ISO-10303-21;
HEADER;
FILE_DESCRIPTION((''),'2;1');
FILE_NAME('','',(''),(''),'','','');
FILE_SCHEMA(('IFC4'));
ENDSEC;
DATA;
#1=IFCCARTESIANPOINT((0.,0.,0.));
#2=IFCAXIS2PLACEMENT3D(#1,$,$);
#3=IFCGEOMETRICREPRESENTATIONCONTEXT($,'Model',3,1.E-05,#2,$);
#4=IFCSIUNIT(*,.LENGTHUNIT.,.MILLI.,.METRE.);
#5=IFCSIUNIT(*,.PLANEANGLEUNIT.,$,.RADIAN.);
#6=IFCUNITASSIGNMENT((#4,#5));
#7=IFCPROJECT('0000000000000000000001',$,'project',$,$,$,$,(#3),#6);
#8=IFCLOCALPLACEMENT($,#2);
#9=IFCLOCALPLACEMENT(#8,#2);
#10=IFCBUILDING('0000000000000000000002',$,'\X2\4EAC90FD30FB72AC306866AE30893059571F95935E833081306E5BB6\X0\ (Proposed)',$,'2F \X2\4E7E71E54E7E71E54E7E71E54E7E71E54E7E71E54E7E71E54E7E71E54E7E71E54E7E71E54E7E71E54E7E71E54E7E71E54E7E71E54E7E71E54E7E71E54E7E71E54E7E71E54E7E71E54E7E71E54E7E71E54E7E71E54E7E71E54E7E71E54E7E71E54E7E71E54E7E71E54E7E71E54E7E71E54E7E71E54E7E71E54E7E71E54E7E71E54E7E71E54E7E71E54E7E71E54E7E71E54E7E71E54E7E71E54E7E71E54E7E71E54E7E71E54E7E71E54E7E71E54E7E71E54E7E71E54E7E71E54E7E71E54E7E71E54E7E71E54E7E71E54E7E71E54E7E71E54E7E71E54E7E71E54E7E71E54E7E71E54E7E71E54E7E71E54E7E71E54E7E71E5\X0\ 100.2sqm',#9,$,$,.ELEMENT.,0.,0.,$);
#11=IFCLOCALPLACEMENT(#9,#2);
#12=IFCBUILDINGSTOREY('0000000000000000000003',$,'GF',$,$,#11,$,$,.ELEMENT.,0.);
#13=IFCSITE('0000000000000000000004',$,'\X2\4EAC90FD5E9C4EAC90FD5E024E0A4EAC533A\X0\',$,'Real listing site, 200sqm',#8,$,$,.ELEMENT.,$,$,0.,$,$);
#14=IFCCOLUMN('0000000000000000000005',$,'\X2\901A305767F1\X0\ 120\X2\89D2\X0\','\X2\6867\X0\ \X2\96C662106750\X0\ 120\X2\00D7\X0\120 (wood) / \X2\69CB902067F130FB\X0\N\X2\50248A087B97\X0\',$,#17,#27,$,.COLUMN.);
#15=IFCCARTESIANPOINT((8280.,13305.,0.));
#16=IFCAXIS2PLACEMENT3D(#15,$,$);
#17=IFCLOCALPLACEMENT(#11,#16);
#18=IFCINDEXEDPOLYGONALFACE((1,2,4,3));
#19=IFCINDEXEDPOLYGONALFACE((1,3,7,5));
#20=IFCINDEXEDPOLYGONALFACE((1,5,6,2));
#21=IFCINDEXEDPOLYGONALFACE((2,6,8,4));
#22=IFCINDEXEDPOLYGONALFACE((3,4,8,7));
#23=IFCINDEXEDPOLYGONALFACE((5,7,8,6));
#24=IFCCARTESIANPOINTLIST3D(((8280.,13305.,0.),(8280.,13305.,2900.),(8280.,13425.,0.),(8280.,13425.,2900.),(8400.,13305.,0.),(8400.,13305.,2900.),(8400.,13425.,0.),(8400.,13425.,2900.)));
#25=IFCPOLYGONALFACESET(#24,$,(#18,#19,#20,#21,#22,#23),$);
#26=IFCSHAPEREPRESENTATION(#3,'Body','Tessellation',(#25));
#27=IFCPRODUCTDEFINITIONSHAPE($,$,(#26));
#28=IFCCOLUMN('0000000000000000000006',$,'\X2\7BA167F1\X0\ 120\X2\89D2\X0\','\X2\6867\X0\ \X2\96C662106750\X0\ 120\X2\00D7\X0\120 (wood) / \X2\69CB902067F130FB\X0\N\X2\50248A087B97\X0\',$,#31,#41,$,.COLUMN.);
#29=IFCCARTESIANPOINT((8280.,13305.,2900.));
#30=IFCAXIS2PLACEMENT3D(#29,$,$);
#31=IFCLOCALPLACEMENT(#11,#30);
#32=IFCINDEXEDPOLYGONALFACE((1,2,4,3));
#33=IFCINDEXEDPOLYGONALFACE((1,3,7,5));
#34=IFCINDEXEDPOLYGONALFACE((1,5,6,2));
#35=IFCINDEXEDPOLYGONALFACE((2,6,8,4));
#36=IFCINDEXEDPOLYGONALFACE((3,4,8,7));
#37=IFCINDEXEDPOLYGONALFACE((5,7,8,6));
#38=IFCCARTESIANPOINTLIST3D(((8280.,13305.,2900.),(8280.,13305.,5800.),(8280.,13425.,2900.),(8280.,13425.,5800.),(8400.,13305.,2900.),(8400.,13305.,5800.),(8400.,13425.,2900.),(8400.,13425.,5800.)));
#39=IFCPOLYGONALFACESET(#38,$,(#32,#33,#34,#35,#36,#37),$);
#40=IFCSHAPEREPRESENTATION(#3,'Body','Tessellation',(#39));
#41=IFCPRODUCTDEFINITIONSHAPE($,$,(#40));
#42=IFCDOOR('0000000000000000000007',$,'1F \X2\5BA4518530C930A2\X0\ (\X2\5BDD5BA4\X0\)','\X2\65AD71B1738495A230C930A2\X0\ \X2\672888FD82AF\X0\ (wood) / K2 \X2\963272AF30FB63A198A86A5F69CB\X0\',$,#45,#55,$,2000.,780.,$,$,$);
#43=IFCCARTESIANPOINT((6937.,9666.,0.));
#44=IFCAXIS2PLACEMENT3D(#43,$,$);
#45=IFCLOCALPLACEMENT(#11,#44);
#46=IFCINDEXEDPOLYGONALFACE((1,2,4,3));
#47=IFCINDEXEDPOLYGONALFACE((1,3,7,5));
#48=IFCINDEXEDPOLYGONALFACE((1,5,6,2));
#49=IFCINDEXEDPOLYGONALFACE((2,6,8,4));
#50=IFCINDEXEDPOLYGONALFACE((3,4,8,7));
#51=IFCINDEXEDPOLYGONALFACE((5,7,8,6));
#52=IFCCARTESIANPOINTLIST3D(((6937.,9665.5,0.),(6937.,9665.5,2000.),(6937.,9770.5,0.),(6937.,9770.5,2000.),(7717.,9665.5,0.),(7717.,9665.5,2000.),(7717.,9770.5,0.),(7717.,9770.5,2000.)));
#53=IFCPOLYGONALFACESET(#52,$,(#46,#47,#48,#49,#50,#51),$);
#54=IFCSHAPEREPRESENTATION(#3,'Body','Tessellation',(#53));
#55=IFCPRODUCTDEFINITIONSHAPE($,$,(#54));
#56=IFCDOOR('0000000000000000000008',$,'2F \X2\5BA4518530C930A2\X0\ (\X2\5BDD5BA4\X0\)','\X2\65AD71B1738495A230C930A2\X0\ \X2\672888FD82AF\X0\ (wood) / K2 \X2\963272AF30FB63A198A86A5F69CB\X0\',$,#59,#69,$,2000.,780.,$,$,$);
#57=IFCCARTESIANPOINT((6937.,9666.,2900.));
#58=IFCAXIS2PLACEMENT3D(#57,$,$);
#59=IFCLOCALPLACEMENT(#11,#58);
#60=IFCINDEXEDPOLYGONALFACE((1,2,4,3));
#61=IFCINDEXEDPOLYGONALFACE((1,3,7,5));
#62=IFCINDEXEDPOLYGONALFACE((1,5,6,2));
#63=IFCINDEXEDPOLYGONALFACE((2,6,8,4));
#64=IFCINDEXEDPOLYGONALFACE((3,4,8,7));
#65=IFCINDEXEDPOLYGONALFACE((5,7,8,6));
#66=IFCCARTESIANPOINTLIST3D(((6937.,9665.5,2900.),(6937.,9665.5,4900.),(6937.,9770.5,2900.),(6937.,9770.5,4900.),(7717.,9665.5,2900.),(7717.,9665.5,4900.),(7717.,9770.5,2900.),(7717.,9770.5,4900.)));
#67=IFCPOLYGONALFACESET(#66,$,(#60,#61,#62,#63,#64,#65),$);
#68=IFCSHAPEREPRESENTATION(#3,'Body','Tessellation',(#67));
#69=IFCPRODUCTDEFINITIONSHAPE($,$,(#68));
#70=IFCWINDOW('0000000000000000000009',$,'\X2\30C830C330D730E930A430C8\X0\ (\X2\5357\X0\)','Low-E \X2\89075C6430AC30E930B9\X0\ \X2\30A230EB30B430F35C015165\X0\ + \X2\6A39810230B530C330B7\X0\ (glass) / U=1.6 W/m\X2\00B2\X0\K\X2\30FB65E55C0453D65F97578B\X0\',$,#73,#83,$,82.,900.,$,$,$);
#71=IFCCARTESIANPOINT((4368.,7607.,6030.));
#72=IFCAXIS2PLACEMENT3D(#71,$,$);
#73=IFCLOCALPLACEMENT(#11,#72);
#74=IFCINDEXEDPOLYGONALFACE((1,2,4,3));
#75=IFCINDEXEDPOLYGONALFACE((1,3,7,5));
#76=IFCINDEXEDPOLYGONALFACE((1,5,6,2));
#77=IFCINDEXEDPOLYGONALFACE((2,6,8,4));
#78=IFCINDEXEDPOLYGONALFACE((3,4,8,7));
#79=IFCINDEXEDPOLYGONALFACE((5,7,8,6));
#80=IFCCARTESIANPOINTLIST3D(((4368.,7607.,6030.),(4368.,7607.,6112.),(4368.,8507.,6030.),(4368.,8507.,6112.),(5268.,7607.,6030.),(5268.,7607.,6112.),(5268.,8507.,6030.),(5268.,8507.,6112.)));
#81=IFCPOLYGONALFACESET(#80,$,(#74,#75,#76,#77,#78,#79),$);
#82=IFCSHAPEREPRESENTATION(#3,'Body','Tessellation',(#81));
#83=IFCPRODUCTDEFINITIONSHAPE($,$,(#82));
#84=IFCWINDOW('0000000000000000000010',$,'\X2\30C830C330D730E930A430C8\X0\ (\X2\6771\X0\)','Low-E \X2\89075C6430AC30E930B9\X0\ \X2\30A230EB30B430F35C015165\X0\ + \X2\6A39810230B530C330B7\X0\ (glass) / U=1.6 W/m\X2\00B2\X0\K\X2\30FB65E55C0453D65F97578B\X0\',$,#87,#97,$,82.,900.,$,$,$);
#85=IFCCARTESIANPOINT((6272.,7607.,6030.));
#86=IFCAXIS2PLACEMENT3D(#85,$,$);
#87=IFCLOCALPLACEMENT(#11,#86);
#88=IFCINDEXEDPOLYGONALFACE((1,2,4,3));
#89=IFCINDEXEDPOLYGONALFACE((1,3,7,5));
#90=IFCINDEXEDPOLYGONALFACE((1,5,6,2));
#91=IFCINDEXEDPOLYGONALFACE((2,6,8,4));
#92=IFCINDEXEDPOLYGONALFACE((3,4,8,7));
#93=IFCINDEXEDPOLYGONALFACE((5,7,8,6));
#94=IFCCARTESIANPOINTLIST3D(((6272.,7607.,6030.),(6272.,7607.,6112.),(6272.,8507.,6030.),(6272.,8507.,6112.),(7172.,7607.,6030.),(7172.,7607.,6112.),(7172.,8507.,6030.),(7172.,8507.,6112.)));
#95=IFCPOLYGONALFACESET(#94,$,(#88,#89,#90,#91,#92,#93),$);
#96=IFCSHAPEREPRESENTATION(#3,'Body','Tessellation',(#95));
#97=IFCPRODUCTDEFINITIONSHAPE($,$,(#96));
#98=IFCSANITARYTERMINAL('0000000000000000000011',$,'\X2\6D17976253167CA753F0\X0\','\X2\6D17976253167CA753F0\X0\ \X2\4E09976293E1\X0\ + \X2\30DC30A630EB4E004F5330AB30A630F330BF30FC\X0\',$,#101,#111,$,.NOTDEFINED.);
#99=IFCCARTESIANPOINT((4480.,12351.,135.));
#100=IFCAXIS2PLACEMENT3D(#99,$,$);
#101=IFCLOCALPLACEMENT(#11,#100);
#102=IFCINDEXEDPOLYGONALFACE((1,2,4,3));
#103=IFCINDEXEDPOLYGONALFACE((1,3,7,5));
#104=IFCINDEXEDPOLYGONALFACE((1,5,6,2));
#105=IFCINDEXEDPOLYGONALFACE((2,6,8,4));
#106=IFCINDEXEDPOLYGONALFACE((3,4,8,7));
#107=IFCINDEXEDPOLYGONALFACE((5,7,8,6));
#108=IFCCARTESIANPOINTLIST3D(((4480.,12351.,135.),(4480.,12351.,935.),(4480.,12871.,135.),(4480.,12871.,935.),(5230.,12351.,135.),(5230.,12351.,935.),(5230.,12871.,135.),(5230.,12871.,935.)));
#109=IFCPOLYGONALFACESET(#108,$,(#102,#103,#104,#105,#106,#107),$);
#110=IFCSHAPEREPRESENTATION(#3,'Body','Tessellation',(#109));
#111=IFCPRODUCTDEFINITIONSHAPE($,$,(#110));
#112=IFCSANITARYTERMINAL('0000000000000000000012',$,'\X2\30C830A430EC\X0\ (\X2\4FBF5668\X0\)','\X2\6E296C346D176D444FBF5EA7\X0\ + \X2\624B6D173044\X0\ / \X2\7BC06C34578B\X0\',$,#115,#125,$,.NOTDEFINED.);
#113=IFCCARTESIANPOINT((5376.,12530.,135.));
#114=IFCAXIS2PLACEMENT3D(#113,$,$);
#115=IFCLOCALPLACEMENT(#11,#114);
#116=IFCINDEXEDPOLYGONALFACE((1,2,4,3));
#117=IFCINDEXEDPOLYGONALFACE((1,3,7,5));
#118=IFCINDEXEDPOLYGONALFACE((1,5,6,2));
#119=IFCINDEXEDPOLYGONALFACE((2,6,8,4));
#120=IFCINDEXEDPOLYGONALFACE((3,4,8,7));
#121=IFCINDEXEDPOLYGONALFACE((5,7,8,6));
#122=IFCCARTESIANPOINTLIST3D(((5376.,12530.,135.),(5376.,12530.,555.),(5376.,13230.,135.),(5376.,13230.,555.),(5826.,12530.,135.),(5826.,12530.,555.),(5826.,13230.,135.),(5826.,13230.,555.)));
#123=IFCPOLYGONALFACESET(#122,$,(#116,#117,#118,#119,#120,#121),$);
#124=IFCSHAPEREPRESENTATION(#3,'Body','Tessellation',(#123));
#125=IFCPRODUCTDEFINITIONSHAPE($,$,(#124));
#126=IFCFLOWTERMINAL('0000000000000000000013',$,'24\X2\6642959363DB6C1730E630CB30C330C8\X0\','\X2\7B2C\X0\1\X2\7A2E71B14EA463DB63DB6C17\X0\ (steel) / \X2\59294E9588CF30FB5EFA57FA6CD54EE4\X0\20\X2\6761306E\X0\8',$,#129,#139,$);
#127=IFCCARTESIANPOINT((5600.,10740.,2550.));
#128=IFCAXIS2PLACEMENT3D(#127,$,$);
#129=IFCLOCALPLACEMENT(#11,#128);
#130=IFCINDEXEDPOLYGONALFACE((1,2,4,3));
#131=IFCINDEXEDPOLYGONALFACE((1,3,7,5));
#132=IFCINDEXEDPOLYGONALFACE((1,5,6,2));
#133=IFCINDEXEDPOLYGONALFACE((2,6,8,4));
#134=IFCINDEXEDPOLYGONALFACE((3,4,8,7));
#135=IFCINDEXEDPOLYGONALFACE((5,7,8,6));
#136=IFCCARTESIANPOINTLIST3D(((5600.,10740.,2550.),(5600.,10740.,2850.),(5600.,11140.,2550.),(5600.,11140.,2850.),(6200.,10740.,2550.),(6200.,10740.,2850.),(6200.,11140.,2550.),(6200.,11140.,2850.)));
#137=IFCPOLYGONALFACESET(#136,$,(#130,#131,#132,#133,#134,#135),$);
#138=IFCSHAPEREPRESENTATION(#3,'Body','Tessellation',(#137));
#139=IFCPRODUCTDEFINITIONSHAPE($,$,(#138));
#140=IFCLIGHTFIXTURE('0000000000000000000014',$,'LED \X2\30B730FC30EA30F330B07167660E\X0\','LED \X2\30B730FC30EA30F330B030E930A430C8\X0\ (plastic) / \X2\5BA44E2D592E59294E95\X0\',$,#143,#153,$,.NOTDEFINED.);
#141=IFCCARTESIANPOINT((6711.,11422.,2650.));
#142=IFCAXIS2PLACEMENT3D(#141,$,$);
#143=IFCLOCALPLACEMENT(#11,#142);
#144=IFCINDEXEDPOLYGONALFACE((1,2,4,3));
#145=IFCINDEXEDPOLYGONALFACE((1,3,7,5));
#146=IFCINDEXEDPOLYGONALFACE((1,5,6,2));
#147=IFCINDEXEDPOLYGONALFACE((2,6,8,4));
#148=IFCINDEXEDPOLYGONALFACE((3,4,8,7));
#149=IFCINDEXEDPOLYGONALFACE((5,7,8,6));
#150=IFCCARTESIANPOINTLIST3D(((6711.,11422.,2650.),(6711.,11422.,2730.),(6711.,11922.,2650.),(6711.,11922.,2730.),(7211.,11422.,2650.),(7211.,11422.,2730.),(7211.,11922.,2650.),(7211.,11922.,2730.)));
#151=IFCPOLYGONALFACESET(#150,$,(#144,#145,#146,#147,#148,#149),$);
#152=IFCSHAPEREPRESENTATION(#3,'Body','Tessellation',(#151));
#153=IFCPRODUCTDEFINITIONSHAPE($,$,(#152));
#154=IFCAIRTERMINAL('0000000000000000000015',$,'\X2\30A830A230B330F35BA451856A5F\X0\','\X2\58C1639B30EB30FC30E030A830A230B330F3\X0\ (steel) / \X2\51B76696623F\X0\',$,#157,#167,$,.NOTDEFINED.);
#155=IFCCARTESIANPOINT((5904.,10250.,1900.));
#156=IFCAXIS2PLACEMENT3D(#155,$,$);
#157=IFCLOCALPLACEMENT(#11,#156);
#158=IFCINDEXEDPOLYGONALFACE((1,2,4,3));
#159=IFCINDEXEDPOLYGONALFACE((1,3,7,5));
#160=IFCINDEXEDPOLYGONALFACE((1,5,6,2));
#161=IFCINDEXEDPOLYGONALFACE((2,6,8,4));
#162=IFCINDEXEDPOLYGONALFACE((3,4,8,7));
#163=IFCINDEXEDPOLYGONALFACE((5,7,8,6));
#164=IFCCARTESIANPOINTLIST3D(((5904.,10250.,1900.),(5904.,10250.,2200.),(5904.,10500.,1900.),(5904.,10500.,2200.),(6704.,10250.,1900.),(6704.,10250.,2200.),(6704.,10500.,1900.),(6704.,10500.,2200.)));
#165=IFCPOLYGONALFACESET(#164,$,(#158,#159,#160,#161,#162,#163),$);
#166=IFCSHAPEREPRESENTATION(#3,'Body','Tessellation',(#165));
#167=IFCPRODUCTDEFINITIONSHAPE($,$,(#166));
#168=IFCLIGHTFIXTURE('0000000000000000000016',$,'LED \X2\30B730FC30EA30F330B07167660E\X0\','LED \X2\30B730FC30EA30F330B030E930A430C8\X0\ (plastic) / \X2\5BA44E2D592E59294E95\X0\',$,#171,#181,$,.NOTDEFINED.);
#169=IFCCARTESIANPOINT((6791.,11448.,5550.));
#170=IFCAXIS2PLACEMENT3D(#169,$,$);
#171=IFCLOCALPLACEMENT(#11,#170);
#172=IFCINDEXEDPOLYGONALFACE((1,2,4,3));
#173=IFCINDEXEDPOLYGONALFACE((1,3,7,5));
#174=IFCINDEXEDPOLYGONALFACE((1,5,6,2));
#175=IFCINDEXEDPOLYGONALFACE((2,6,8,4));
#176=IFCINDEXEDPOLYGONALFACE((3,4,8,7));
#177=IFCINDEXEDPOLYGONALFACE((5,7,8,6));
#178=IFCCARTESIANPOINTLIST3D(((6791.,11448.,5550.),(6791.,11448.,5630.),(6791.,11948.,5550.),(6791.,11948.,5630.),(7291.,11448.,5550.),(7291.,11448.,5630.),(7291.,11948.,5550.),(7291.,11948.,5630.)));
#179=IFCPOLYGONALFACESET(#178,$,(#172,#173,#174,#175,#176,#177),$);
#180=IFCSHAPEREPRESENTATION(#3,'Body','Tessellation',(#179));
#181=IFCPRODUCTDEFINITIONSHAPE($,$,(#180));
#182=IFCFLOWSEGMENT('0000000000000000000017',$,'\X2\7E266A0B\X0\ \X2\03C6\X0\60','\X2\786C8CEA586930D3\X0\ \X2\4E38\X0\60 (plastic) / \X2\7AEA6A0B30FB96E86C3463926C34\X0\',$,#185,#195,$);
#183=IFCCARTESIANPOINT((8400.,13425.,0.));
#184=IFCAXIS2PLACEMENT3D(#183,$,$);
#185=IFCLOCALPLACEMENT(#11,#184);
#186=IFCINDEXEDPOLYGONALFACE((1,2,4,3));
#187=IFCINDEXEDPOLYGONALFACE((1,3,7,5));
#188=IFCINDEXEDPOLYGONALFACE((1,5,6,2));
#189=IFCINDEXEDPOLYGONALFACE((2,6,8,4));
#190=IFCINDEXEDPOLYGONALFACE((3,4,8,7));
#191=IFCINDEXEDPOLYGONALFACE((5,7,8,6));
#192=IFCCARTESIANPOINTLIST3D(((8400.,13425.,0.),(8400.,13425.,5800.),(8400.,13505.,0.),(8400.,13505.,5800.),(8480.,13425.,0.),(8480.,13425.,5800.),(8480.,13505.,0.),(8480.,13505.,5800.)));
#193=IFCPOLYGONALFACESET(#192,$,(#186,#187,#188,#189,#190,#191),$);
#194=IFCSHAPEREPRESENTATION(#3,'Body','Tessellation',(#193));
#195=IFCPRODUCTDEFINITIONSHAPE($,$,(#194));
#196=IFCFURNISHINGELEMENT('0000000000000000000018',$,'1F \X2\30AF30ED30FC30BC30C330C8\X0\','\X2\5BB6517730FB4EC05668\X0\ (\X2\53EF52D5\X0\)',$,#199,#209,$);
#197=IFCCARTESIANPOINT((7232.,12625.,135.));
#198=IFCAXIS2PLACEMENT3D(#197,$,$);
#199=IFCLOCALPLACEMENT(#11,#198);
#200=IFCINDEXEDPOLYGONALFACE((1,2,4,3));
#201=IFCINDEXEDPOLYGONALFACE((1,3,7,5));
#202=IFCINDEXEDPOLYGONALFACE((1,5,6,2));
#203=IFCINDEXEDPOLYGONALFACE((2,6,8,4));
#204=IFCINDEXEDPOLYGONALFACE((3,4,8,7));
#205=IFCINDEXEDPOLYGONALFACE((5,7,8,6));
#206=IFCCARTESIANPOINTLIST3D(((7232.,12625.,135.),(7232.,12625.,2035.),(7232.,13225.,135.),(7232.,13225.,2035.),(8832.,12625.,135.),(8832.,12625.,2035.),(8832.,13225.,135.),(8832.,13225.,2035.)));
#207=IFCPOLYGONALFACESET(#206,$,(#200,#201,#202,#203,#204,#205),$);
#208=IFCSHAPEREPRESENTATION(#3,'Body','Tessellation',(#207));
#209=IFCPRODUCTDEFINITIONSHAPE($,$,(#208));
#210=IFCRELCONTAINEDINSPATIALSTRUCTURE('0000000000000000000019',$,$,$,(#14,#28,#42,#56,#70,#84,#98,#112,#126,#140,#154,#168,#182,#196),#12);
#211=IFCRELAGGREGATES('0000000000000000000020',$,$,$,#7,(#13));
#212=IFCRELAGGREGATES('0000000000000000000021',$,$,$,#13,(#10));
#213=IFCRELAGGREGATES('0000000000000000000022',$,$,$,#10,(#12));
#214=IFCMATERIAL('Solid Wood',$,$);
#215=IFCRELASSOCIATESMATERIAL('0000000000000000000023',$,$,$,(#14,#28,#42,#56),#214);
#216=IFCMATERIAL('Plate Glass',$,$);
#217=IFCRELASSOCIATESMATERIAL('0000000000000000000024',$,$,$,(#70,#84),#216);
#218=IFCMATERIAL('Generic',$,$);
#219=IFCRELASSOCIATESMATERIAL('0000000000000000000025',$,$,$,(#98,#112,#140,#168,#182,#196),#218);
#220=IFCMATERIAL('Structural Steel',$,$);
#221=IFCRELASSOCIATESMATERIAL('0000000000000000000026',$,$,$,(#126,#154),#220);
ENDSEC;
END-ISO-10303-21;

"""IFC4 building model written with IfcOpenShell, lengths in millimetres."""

from ifc_helpers import new_model, si_unit, frame, frame_2d, origin, place, context, project, spatial, rectangle, extrude, material, element, save


model = new_model("IFC4")

# Units and contexts
model_context = context("Model", 3, precision=1e-05, world=origin())
ifc_project = project(units=[si_unit("LENGTHUNIT", "METRE", prefix="MILLI"), si_unit("PLANEANGLEUNIT", "RADIAN")], contexts=[model_context])

# Site, building, storey
site_placement = place(None, origin())
site = spatial("IfcSite", under=ifc_project, at=site_placement, Name="京都府京都市上京区", ObjectType="Real listing site, 200sqm", CompositionType="ELEMENT", RefElevation=0.0)
building_placement = place(site_placement, origin())
building = spatial("IfcBuilding", under=site, at=building_placement, Name="京都・犬と暮らす土間広めの家 (Proposed)", ObjectType="2F 乾燥乾燥乾燥乾燥乾燥乾燥乾燥乾燥乾燥乾燥乾燥乾燥乾燥乾燥乾燥乾燥乾燥乾燥乾燥乾燥乾燥乾燥乾燥乾燥乾燥乾燥乾燥乾燥乾燥乾燥乾燥乾燥乾燥乾燥乾燥乾燥乾燥乾燥乾燥乾燥乾燥乾燥乾燥乾燥乾燥乾燥乾燥乾燥乾燥乾燥乾燥乾燥乾燥乾燥乾燥乾燥乾燥乾燥乾燥乾燥 100.2sqm", CompositionType="ELEMENT", ElevationOfRefHeight=0.0, ElevationOfTerrain=0.0)
storey_placement = place(building_placement, origin())
storey = spatial("IfcBuildingStorey", under=building, at=storey_placement, Name="GF", CompositionType="ELEMENT", Elevation=0.0)

# Columns
ifc_material_1 = material(Name="Solid Wood")
column_1_placement = place(storey_placement, frame((8280.0, 13305.0, 0.0)))
element("IfcColumn", 1, at=column_1_placement, inside=storey, material=ifc_material_1, Name="通し柱 120角", Description="桧 集成材 120×120 (wood) / 構造柱・N値計算", PredefinedType="COLUMN", context=model_context, shape_type="SweptSolid", body=[
    extrude(rectangle(XDim=120.0, YDim=120.0, at=frame_2d((60.0, 60.0))), frame((8280.0, 13305.0, 0.0)), (0.0, 0.0, 1.0), 2900.0),
])
column_2_placement = place(storey_placement, frame((8280.0, 13305.0, 2900.0)))
element("IfcColumn", 2, at=column_2_placement, inside=storey, material=ifc_material_1, Name="管柱 120角", Description="桧 集成材 120×120 (wood) / 構造柱・N値計算", PredefinedType="COLUMN", context=model_context, shape_type="SweptSolid", body=[
    extrude(rectangle(XDim=120.0, YDim=120.0, at=frame_2d((60.0, 60.0))), frame((8280.0, 13305.0, 2900.0)), (0.0, 0.0, 1.0), 2900.0),
])

# Door
door_1_placement = place(storey_placement, frame((6937.0, 9666.0, 0.0)))
element("IfcDoor", 3, at=door_1_placement, inside=storey, material=ifc_material_1, Name="1F 室内ドア (寝室)", Description="断熱玄関ドア 木製芯 (wood) / K2 防犯・採風機構", OverallHeight=2000.0, OverallWidth=780.0, context=model_context, shape_type="SweptSolid", body=[
    extrude(rectangle(XDim=780.0, YDim=105.0, at=frame_2d((390.0, 52.0))), frame((6937.0, 9666.0, 0.0)), (0.0, 0.0, 1.0), 2000.0),
])

# Door
door_2_placement = place(storey_placement, frame((6937.0, 9666.0, 2900.0)))
element("IfcDoor", 4, at=door_2_placement, inside=storey, material=ifc_material_1, Name="2F 室内ドア (寝室)", Description="断熱玄関ドア 木製芯 (wood) / K2 防犯・採風機構", OverallHeight=2000.0, OverallWidth=780.0, context=model_context, shape_type="SweptSolid", body=[
    extrude(rectangle(XDim=780.0, YDim=105.0, at=frame_2d((390.0, 52.0))), frame((6937.0, 9666.0, 2900.0)), (0.0, 0.0, 1.0), 2000.0),
])

# Windows
ifc_material_2 = material(Name="Plate Glass")
window_1_placement = place(storey_placement, frame((4368.0, 7607.0, 6030.0)))
element("IfcWindow", 5, at=window_1_placement, inside=storey, material=ifc_material_2, Name="トップライト (南)", Description="Low-E 複層ガラス アルゴン封入 + 樹脂サッシ (glass) / U=1.6 W/m²K・日射取得型", OverallHeight=82.0, OverallWidth=900.0, context=model_context, shape_type="SweptSolid", body=[
    extrude(rectangle(XDim=900.0, YDim=900.0, at=frame_2d((450.0, 450.0))), frame((4368.0, 7607.0, 6030.0)), (0.0, 0.0, 1.0), 82.0),
])
window_2_placement = place(storey_placement, frame((6272.0, 7607.0, 6030.0)))
element("IfcWindow", 6, at=window_2_placement, inside=storey, material=ifc_material_2, Name="トップライト (東)", Description="Low-E 複層ガラス アルゴン封入 + 樹脂サッシ (glass) / U=1.6 W/m²K・日射取得型", OverallHeight=82.0, OverallWidth=900.0, context=model_context, shape_type="SweptSolid", body=[
    extrude(rectangle(XDim=900.0, YDim=900.0, at=frame_2d((450.0, 450.0))), frame((6272.0, 7607.0, 6030.0)), (0.0, 0.0, 1.0), 82.0),
])

# Sanitary terminals
ifc_material_3 = material(Name="Generic")
sanitary_terminal_1_placement = place(storey_placement, frame((4480.0, 12351.0, 135.0)))
element("IfcSanitaryTerminal", 7, at=sanitary_terminal_1_placement, inside=storey, material=ifc_material_3, Name="洗面化粧台", Description="洗面化粧台 三面鏡 + ボウル一体カウンター", PredefinedType="NOTDEFINED", context=model_context, shape_type="SweptSolid", body=[
    extrude(rectangle(XDim=750.0, YDim=520.0, at=frame_2d((375.0, 260.0))), frame((4480.0, 12351.0, 135.0)), (0.0, 0.0, 1.0), 800.0),
])
sanitary_terminal_2_placement = place(storey_placement, frame((5376.0, 12530.0, 135.0)))
element("IfcSanitaryTerminal", 8, at=sanitary_terminal_2_placement, inside=storey, material=ifc_material_3, Name="トイレ (便器)", Description="温水洗浄便座 + 手洗い / 節水型", PredefinedType="NOTDEFINED", context=model_context, shape_type="SweptSolid", body=[
    extrude(rectangle(XDim=450.0, YDim=700.0, at=frame_2d((225.0, 350.0))), frame((5376.0, 12530.0, 135.0)), (0.0, 0.0, 1.0), 420.0),
])

# Flow terminal
ifc_material_4 = material(Name="Structural Steel")
flow_terminal_placement = place(storey_placement, frame((5600.0, 10740.0, 2550.0)))
element("IfcFlowTerminal", 9, at=flow_terminal_placement, inside=storey, material=ifc_material_4, Name="24時間換気ユニット", Description="第1種熱交換換気 (steel) / 天井裏・建基法令20条の8", context=model_context, shape_type="SweptSolid", body=[
    extrude(rectangle(XDim=600.0, YDim=400.0, at=frame_2d((300.0, 200.0))), frame((5600.0, 10740.0, 2550.0)), (0.0, 0.0, 1.0), 300.0),
])

# Light fixture
light_fixture_1_placement = place(storey_placement, frame((6711.0, 11422.0, 2650.0)))
element("IfcLightFixture", 10, at=light_fixture_1_placement, inside=storey, material=ifc_material_3, Name="LED シーリング照明", Description="LED シーリングライト (plastic) / 室中央天井", PredefinedType="NOTDEFINED", context=model_context, shape_type="SweptSolid", body=[
    extrude(rectangle(XDim=500.0, YDim=500.0, at=frame_2d((250.0, 250.0))), frame((6711.0, 11422.0, 2650.0)), (0.0, 0.0, 1.0), 80.0),
])

# Air terminal
air_terminal_placement = place(storey_placement, frame((5904.0, 10250.0, 1900.0)))
element("IfcAirTerminal", 11, at=air_terminal_placement, inside=storey, material=ifc_material_4, Name="エアコン室内機", Description="壁掛ルームエアコン (steel) / 冷暖房", PredefinedType="NOTDEFINED", context=model_context, shape_type="SweptSolid", body=[
    extrude(rectangle(XDim=800.0, YDim=250.0, at=frame_2d((400.0, 125.0))), frame((5904.0, 10250.0, 1900.0)), (0.0, 0.0, 1.0), 300.0),
])

# Light fixture
light_fixture_2_placement = place(storey_placement, frame((6791.0, 11448.0, 5550.0)))
element("IfcLightFixture", 12, at=light_fixture_2_placement, inside=storey, material=ifc_material_3, Name="LED シーリング照明", Description="LED シーリングライト (plastic) / 室中央天井", PredefinedType="NOTDEFINED", context=model_context, shape_type="SweptSolid", body=[
    extrude(rectangle(XDim=500.0, YDim=500.0, at=frame_2d((250.0, 250.0))), frame((6791.0, 11448.0, 5550.0)), (0.0, 0.0, 1.0), 80.0),
])

# Flow segment
flow_segment_placement = place(storey_placement, frame((8400.0, 13425.0, 0.0)))
element("IfcFlowSegment", 13, at=flow_segment_placement, inside=storey, material=ifc_material_3, Name="縦樋 φ60", Description="硬質塩ビ 丸60 (plastic) / 竪樋・雨水排水", context=model_context, shape_type="SweptSolid", body=[
    extrude(rectangle(XDim=80.0, YDim=80.0, at=frame_2d((40.0, 40.0))), frame((8400.0, 13425.0, 0.0)), (0.0, 0.0, 1.0), 5800.0),
])

# Furnishing element
furnishing_1_placement = place(storey_placement, frame((7232.0, 12625.0, 135.0)))
element("IfcFurnishingElement", 14, at=furnishing_1_placement, inside=storey, material=ifc_material_3, Name="1F クローゼット", Description="家具・什器 (可動)", context=model_context, shape_type="SweptSolid", body=[
    extrude(rectangle(XDim=1600.0, YDim=600.0, at=frame_2d((800.0, 300.0))), frame((7232.0, 12625.0, 135.0)), (0.0, 0.0, 1.0), 1900.0),
])

save(model, "model.ifc")
